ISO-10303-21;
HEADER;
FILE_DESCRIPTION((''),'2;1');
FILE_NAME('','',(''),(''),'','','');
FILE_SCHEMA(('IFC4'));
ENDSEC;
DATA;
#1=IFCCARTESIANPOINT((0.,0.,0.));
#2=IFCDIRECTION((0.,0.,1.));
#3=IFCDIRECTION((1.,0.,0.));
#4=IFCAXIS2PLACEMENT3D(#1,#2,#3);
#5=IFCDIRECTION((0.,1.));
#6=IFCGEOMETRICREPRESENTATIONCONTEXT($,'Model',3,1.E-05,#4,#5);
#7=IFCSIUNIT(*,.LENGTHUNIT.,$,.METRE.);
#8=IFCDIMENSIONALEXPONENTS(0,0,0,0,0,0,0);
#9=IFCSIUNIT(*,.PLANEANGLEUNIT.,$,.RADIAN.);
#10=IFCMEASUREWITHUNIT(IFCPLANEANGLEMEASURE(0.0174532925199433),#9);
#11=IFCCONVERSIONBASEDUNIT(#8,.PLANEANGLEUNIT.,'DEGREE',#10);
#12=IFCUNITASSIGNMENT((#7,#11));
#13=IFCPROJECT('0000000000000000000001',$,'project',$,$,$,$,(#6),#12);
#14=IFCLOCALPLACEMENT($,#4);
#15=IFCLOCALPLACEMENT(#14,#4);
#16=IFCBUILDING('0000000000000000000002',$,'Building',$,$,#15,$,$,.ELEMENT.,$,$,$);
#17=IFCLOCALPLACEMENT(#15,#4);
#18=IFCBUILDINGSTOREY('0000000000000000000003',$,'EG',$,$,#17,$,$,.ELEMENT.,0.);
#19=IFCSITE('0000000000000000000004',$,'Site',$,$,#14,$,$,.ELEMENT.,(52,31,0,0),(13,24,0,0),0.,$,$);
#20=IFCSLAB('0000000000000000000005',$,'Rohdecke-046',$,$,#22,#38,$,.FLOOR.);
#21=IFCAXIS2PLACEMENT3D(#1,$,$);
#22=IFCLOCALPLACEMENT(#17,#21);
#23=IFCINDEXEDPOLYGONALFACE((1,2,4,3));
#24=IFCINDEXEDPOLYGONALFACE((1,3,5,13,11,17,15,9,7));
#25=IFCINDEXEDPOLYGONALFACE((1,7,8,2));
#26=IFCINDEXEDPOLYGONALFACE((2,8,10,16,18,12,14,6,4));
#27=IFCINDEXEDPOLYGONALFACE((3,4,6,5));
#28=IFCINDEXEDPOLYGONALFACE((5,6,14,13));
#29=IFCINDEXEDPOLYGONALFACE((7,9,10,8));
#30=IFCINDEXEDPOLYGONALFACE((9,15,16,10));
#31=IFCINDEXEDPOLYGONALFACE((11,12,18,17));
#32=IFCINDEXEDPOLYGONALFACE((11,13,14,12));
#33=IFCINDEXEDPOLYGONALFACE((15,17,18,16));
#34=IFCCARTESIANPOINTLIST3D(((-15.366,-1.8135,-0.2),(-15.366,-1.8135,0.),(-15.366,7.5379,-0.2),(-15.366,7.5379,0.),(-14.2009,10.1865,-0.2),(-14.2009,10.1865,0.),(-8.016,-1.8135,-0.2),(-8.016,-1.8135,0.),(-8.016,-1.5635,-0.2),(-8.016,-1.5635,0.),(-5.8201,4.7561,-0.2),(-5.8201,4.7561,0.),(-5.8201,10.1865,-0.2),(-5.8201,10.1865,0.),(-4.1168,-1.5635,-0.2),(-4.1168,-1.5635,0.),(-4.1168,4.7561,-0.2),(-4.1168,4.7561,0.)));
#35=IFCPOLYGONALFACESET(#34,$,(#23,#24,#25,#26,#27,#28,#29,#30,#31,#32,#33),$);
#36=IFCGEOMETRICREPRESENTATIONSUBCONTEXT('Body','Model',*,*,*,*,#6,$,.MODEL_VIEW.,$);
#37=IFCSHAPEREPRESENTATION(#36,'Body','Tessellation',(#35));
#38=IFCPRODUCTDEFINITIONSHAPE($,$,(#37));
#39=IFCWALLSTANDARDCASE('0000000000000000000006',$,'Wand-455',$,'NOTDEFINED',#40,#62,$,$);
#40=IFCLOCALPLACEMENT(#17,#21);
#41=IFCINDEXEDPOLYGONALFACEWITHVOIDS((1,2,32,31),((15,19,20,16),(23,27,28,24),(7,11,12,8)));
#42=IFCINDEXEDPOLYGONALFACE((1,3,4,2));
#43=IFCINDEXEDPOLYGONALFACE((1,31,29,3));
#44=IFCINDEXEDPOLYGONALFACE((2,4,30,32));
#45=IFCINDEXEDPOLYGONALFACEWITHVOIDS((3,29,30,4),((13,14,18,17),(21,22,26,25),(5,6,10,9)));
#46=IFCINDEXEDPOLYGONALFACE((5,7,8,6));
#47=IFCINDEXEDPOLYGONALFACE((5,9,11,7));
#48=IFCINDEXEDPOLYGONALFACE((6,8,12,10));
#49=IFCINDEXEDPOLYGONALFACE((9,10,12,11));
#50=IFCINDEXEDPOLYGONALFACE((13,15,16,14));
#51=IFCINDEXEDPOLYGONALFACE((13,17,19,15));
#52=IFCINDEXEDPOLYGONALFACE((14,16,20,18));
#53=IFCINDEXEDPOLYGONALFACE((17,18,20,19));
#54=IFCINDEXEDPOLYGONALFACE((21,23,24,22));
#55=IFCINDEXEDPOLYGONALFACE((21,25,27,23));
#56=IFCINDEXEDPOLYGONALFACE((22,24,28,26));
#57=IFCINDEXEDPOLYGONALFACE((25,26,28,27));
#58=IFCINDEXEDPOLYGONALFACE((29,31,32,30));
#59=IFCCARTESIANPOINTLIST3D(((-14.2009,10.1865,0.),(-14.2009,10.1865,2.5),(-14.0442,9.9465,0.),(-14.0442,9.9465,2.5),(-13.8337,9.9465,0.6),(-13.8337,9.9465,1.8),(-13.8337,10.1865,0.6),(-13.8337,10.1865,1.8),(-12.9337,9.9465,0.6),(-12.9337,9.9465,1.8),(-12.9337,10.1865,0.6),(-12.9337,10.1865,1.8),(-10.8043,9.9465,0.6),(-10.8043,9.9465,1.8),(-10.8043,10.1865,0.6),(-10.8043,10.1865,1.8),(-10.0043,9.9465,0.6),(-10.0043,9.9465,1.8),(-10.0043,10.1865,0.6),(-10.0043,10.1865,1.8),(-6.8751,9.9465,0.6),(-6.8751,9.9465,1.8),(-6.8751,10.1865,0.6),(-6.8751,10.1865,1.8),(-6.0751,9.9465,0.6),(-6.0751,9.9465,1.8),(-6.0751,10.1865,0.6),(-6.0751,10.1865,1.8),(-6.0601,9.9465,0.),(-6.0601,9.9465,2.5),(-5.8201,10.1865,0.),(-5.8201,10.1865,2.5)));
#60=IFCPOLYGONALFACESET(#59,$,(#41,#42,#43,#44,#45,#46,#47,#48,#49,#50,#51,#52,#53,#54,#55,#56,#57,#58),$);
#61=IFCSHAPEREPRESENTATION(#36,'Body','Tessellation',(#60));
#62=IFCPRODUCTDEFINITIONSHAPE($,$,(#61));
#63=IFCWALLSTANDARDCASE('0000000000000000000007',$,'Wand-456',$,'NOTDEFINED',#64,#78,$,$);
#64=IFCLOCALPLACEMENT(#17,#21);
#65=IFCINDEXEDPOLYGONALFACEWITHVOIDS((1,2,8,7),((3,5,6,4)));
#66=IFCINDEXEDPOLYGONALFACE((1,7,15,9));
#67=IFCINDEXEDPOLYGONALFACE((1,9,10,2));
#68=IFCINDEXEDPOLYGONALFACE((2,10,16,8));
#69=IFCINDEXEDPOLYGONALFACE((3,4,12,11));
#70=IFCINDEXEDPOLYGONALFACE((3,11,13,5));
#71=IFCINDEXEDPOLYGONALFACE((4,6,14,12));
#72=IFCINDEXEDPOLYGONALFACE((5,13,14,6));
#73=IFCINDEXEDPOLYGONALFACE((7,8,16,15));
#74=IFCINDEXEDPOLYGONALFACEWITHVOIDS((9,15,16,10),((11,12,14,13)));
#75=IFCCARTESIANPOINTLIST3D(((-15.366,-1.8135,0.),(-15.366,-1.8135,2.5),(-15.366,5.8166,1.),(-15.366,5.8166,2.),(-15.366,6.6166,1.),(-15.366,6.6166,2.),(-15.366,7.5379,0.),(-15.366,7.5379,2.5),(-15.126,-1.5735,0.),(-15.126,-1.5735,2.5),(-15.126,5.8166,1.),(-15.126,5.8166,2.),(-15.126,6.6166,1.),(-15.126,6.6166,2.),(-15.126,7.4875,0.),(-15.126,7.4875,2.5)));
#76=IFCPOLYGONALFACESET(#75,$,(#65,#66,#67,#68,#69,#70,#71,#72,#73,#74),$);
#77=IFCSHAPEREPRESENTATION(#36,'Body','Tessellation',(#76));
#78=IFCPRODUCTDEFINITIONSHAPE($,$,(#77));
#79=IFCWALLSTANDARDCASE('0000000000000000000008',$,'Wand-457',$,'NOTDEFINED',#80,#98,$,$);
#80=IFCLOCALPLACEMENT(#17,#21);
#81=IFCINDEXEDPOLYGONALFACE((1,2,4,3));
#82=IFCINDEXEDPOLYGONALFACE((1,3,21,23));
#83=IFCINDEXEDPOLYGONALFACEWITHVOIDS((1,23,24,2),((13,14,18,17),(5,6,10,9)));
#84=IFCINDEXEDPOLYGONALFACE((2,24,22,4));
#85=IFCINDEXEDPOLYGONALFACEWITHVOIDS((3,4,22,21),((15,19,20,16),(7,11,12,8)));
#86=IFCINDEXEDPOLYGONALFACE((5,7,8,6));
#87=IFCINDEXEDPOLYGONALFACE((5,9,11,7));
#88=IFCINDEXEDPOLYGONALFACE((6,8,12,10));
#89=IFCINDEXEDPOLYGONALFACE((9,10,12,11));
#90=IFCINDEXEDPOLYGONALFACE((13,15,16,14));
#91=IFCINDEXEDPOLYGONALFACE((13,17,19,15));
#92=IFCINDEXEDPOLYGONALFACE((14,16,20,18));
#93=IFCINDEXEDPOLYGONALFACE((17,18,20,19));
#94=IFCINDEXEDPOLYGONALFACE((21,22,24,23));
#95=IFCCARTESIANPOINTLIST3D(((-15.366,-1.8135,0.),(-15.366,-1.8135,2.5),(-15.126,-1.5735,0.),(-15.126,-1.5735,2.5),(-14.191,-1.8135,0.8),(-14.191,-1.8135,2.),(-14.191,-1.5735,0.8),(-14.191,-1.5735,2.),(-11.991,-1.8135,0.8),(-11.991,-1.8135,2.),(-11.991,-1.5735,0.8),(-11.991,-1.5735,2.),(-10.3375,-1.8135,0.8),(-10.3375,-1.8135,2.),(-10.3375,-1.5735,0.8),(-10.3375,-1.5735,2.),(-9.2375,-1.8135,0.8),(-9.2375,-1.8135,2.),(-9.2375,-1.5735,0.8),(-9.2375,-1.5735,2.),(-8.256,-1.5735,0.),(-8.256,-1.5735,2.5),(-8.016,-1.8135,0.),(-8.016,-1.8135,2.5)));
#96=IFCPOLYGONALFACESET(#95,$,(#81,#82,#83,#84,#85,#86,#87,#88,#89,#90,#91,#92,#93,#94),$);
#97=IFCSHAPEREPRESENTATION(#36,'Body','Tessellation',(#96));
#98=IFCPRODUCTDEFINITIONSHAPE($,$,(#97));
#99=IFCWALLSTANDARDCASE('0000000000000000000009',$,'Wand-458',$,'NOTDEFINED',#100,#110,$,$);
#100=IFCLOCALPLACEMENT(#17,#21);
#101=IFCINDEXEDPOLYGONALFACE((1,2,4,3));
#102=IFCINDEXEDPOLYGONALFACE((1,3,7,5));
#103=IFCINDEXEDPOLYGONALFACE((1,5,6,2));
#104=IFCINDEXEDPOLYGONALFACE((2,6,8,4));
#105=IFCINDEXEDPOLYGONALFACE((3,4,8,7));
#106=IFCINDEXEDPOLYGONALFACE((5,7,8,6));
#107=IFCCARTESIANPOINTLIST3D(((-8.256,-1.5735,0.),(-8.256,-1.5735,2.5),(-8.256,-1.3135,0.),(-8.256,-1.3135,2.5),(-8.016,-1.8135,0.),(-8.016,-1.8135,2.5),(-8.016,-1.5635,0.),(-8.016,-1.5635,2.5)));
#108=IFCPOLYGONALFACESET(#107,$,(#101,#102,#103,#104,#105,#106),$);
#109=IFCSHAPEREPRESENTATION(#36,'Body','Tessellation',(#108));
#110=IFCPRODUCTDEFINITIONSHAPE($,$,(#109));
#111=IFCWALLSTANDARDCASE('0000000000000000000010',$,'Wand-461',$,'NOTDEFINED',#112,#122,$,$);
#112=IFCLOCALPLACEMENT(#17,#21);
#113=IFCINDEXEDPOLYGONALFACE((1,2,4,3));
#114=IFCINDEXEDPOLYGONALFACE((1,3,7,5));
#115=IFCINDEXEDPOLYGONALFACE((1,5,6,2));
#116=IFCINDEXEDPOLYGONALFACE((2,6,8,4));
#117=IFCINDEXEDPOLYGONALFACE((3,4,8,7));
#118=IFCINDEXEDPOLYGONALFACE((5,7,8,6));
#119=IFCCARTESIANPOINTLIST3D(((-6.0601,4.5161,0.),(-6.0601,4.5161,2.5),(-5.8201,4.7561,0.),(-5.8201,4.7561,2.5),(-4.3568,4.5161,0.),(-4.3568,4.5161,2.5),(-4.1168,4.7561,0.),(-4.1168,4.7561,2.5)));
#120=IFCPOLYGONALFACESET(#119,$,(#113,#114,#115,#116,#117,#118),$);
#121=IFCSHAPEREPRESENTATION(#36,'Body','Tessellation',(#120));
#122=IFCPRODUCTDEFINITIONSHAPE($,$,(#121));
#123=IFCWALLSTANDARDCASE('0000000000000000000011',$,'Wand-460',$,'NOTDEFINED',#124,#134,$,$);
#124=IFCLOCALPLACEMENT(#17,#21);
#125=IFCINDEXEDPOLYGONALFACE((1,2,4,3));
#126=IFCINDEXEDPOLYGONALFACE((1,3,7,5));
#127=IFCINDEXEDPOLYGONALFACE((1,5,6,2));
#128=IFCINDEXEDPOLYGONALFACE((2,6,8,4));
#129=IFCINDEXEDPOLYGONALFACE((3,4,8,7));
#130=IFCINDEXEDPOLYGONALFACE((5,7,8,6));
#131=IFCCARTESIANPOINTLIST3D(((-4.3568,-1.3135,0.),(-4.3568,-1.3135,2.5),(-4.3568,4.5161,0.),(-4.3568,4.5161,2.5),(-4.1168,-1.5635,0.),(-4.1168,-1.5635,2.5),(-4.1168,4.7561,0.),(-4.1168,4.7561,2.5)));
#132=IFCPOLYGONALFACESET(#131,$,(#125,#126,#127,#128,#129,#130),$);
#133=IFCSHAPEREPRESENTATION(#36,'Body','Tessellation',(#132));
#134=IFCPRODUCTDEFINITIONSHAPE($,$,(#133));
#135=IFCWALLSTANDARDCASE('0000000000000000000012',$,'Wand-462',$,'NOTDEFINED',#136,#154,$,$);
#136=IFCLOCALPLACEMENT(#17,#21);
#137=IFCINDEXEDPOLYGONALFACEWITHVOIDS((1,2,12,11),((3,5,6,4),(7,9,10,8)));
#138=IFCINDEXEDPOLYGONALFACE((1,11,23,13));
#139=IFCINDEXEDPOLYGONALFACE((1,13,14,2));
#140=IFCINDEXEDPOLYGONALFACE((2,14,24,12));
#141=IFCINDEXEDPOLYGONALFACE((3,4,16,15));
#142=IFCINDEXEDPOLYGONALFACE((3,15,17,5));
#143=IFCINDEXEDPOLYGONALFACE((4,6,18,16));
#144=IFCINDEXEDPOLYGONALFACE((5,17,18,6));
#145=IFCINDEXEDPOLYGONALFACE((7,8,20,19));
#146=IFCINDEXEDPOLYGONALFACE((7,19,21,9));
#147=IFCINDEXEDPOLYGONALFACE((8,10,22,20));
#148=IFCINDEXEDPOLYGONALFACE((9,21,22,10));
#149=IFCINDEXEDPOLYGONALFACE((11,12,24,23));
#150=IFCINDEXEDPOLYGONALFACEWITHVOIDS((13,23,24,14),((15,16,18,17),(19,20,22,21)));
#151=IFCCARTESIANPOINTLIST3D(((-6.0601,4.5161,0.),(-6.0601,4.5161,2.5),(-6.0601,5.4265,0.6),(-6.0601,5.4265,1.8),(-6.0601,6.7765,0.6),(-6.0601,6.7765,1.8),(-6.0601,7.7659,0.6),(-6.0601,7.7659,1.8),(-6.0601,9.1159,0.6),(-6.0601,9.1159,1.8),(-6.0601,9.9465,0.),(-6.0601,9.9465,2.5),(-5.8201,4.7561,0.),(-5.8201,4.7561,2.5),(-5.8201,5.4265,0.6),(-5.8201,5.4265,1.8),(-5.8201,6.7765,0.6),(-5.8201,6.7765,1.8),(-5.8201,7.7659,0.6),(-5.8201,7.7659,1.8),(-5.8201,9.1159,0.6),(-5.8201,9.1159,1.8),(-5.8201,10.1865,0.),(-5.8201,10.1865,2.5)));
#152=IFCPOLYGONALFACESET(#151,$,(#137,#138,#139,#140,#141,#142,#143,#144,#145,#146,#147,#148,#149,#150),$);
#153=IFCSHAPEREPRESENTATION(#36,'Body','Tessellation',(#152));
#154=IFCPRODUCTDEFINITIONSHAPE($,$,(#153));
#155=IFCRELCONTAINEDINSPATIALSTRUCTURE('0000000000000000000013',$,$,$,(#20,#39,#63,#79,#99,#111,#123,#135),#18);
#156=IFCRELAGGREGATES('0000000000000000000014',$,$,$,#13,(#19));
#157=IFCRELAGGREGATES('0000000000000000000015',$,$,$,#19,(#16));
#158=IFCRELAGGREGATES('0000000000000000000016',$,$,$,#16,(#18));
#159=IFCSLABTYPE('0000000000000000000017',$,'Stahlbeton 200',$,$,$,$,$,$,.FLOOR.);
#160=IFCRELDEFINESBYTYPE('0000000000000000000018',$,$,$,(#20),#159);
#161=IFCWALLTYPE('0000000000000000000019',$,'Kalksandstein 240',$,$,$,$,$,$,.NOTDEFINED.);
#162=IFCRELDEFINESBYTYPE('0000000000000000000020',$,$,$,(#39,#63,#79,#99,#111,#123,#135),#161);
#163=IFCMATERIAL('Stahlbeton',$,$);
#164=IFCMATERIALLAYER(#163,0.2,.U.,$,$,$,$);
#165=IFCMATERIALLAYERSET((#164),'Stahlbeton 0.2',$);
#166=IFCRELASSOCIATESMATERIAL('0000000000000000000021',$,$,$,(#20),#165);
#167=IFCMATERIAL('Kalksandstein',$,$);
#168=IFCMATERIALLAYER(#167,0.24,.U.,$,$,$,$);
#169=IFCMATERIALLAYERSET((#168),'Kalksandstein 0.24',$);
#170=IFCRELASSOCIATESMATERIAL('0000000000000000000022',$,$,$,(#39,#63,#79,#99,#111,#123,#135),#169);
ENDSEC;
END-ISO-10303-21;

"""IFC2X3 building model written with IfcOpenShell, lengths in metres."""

from ifc_helpers import new_model, entity, si_unit, converted_unit, direction, frame, origin_with_axes, origin_2d_with_axis, place, context, subcontext, project, spatial, polyline, rectangle, outline, extrude, material, layer, layer_set, layer_usage, type_object, element, save


model = new_model("IFC2X3")

# Units and contexts
model_context = context("Model", 3, precision=1e-05, world=origin_with_axes(), true_north=direction((0.0, 1.0)))
body_context = subcontext(model_context, "Body", "Model", "MODEL_VIEW")
ifc_project = project(units=[si_unit("LENGTHUNIT", "METRE"), converted_unit("PLANEANGLEUNIT", "DEGREE", entity("IfcPlaneAngleMeasure", 0.0174532925199433), si_unit("PLANEANGLEUNIT", "RADIAN"), dimensions=[0, 0, 0, 0, 0, 0, 0])], contexts=[model_context])

# Site, building, storey
site_placement = place(None, origin_with_axes())
site = spatial("IfcSite", under=ifc_project, at=site_placement, Name="Site", CompositionType="ELEMENT", RefLatitude=(52, 31, 0, 0), RefLongitude=(13, 24, 0, 0), RefElevation=0.0)
building_placement = place(site_placement, origin_with_axes())
building = spatial("IfcBuilding", under=site, at=building_placement, Name="Building", CompositionType="ELEMENT")
storey_placement = place(building_placement, origin_with_axes())
storey = spatial("IfcBuildingStorey", under=building, at=storey_placement, Name="EG", CompositionType="ELEMENT", Elevation=0.0)

# Slab
ifc_material_1 = material(Name="Stahlbeton")
ifc_layer_1 = layer(ifc_material_1, 0.2, ventilated="UNKNOWN")
ifc_layer_set_1 = layer_set([ifc_layer_1], Name="Stahlbeton 0.2")
ifc_layer_usage_1 = layer_usage(ifc_layer_set_1, "AXIS3", "NEGATIVE", 0.2)
slab_type = type_object("IfcSlabType", Name="Stahlbeton 200", PredefinedType="FLOOR")
slab_placement = place(storey_placement, frame((-14.2009, 10.1865, 0.0), z_axis=(0.0, 0.0, 1.0), x_axis=(1.0, 0.0, 0.0)))
element("IfcSlab", 1, at=slab_placement, inside=storey, type_object=slab_type, material=ifc_layer_usage_1, Name="Rohdecke-046", PredefinedType="FLOOR", context=body_context, shape_type="SweptSolid", body=[
    extrude(outline(polyline([(0.0, 0.0), (-1.1652, -2.6486), (-1.1652, -12.0), (6.1848, -12.0), (6.1848, -11.75), (10.084, -11.75), (10.084, -5.4304), (8.3807, -5.4304), (8.3807, 0.0), (0.0, 0.0)])), frame((0.0, 0.0, -0.2), z_axis=(0.0, 0.0, 1.0), x_axis=(1.0, 0.0, 0.0)), (0.0, 0.0, 1.0), 0.2),
])

# Wall, openings
ifc_material_2 = material(Name="Kalksandstein")
ifc_layer_2 = layer(ifc_material_2, 0.24, ventilated="UNKNOWN")
ifc_layer_set_2 = layer_set([ifc_layer_2], Name="Kalksandstein 0.24")
ifc_layer_usage_2 = layer_usage(ifc_layer_set_2, "AXIS2", "POSITIVE", 0.0)
wall_type_1 = type_object("IfcWallType", Name="Kalksandstein 240", PredefinedType="NOTDEFINED")
wall_1_placement = place(storey_placement, frame((-5.8201, 10.1865, 0.0), z_axis=(0.0, 0.0, 1.0), x_axis=(-1.0, 0.0, 0.0)))
wall_1 = element("IfcWallStandardCase", 2, at=wall_1_placement, inside=storey, type_object=wall_type_1, material=ifc_layer_usage_2, Name="Wand-455", ObjectType="NOTDEFINED", context=body_context, shape_type="SweptSolid", body=[
    extrude(outline(polyline([(0.0, 0.0), (8.3807, 0.0), (8.2241, 0.24), (0.24, 0.24), (0.0, 0.0)])), origin_with_axes(), (0.0, 0.0, 1.0), 2.5),
])
opening_1_placement = place(wall_1_placement, frame((7.5636, 0.0, 0.6), z_axis=(0.0, 0.0, 1.0), x_axis=(1.0, 0.0, 0.0)))
element("IfcOpeningElement", 3, at=opening_1_placement, cuts=wall_1, context=body_context, shape_type="SweptSolid", body=[
    extrude(rectangle(XDim=0.9, YDim=1.2, at=origin_2d_with_axis()), frame((0.0, 0.24, 0.6), z_axis=(0.0, 1.0, 0.0), x_axis=(1.0, 0.0, 0.0)), (0.0, 0.0, -1.0), 0.72),
])
opening_2_placement = place(wall_1_placement, frame((0.655, 0.0, 0.6), z_axis=(0.0, 0.0, 1.0), x_axis=(1.0, 0.0, 0.0)))
element("IfcOpeningElement", 4, at=opening_2_placement, cuts=wall_1, context=body_context, shape_type="SweptSolid", body=[
    extrude(rectangle(XDim=0.8, YDim=1.2, at=origin_2d_with_axis()), frame((0.0, 0.24, 0.6), z_axis=(0.0, 1.0, 0.0), x_axis=(1.0, 0.0, 0.0)), (0.0, 0.0, -1.0), 0.72),
])
opening_3_placement = place(wall_1_placement, frame((4.5842, 0.0, 0.6), z_axis=(0.0, 0.0, 1.0), x_axis=(1.0, 0.0, 0.0)))
element("IfcOpeningElement", 5, at=opening_3_placement, cuts=wall_1, context=body_context, shape_type="SweptSolid", body=[
    extrude(rectangle(XDim=0.8, YDim=1.2, at=origin_2d_with_axis()), frame((0.0, 0.24, 0.6), z_axis=(0.0, 1.0, 0.0), x_axis=(1.0, 0.0, 0.0)), (0.0, 0.0, -1.0), 0.72),
])

# Wall, opening
ifc_layer_usage_3 = layer_usage(ifc_layer_set_2, "AXIS2", "POSITIVE", 0.0)
wall_2_placement = place(storey_placement, frame((-15.366, 7.5379, 0.0), z_axis=(0.0, 0.0, 1.0), x_axis=(0.0, -1.0, 0.0)))
wall_2 = element("IfcWallStandardCase", 6, at=wall_2_placement, inside=storey, type_object=wall_type_1, material=ifc_layer_usage_3, Name="Wand-456", ObjectType="NOTDEFINED", context=body_context, shape_type="SweptSolid", body=[
    extrude(outline(polyline([(0.0, 0.0), (9.3514, 0.0), (9.1114, 0.24), (0.0505, 0.24), (0.0, 0.0)])), origin_with_axes(), (0.0, 0.0, 1.0), 2.5),
])
opening_4_placement = place(wall_2_placement, frame((1.3213, 0.0, 1.0), z_axis=(0.0, 0.0, 1.0), x_axis=(1.0, 0.0, 0.0)))
element("IfcOpeningElement", 7, at=opening_4_placement, cuts=wall_2, context=body_context, shape_type="SweptSolid", body=[
    extrude(rectangle(XDim=0.8, YDim=1.0, at=origin_2d_with_axis()), frame((0.0, 0.24, 0.5), z_axis=(0.0, 1.0, 0.0), x_axis=(1.0, 0.0, 0.0)), (0.0, 0.0, -1.0), 0.72),
])

# Wall, openings
ifc_layer_usage_4 = layer_usage(ifc_layer_set_2, "AXIS2", "POSITIVE", 0.0)
wall_3_placement = place(storey_placement, frame((-15.366, -1.8135, 0.0), z_axis=(0.0, 0.0, 1.0), x_axis=(1.0, 0.0, 0.0)))
wall_3 = element("IfcWallStandardCase", 8, at=wall_3_placement, inside=storey, type_object=wall_type_1, material=ifc_layer_usage_4, Name="Wand-457", ObjectType="NOTDEFINED", context=body_context, shape_type="SweptSolid", body=[
    extrude(outline(polyline([(0.0, 0.0), (7.35, 0.0), (7.11, 0.24), (0.24, 0.24), (0.0, 0.0)])), origin_with_axes(), (0.0, 0.0, 1.0), 2.5),
])
opening_5_placement = place(wall_3_placement, frame((5.5785, 0.0, 0.8), z_axis=(0.0, 0.0, 1.0), x_axis=(1.0, 0.0, 0.0)))
element("IfcOpeningElement", 9, at=opening_5_placement, cuts=wall_3, context=body_context, shape_type="SweptSolid", body=[
    extrude(rectangle(XDim=1.1, YDim=1.2, at=origin_2d_with_axis()), frame((0.0, 0.24, 0.6), z_axis=(0.0, 1.0, 0.0), x_axis=(1.0, 0.0, 0.0)), (0.0, 0.0, -1.0), 0.72),
])
opening_6_placement = place(wall_3_placement, frame((2.275, 0.0, 0.8), z_axis=(0.0, 0.0, 1.0), x_axis=(1.0, 0.0, 0.0)))
element("IfcOpeningElement", 10, at=opening_6_placement, cuts=wall_3, context=body_context, shape_type="SweptSolid", body=[
    extrude(rectangle(XDim=2.2, YDim=1.2, at=origin_2d_with_axis()), frame((0.0, 0.24, 0.6), z_axis=(0.0, 1.0, 0.0), x_axis=(1.0, 0.0, 0.0)), (0.0, 0.0, -1.0), 0.72),
])

# Walls
ifc_layer_usage_5 = layer_usage(ifc_layer_set_2, "AXIS2", "POSITIVE", 0.0)
wall_4_placement = place(storey_placement, frame((-8.016, -1.8135, 0.0), z_axis=(0.0, 0.0, 1.0), x_axis=(0.0, 1.0, 0.0)))
element("IfcWallStandardCase", 11, at=wall_4_placement, inside=storey, type_object=wall_type_1, material=ifc_layer_usage_5, Name="Wand-458", ObjectType="NOTDEFINED", context=body_context, shape_type="SweptSolid", body=[
    extrude(outline(polyline([(0.0, 0.0), (0.25, 0.0), (0.5, 0.24), (0.24, 0.24), (0.0, 0.0)])), origin_with_axes(), (0.0, 0.0, 1.0), 2.5),
])
ifc_layer_usage_6 = layer_usage(ifc_layer_set_2, "AXIS2", "POSITIVE", 0.0)
wall_5_placement = place(storey_placement, frame((-4.1168, 4.7561, 0.0), z_axis=(0.0, 0.0, 1.0), x_axis=(-1.0, 0.0, 0.0)))
element("IfcWallStandardCase", 12, at=wall_5_placement, inside=storey, type_object=wall_type_1, material=ifc_layer_usage_6, Name="Wand-461", ObjectType="NOTDEFINED", context=body_context, shape_type="SweptSolid", body=[
    extrude(outline(polyline([(0.0, 0.0), (1.7033, 0.0), (1.9433, 0.24), (0.24, 0.24), (0.0, 0.0)])), origin_with_axes(), (0.0, 0.0, 1.0), 2.5),
])
ifc_layer_usage_7 = layer_usage(ifc_layer_set_2, "AXIS2", "POSITIVE", 0.0)
wall_6_placement = place(storey_placement, frame((-4.1168, -1.5635, 0.0), z_axis=(0.0, 0.0, 1.0), x_axis=(0.0, 1.0, 0.0)))
element("IfcWallStandardCase", 13, at=wall_6_placement, inside=storey, type_object=wall_type_1, material=ifc_layer_usage_7, Name="Wand-460", ObjectType="NOTDEFINED", context=body_context, shape_type="SweptSolid", body=[
    extrude(outline(polyline([(0.0, 0.0), (6.3196, 0.0), (6.0796, 0.24), (0.25, 0.24), (0.0, 0.0)])), origin_with_axes(), (0.0, 0.0, 1.0), 2.5),
])

# Wall, openings
ifc_layer_usage_8 = layer_usage(ifc_layer_set_2, "AXIS2", "POSITIVE", 0.0)
wall_7_placement = place(storey_placement, frame((-5.8201, 4.7561, 0.0), z_axis=(0.0, 0.0, 1.0), x_axis=(0.0, 1.0, 0.0)))
wall_7 = element("IfcWallStandardCase", 14, at=wall_7_placement, inside=storey, type_object=wall_type_1, material=ifc_layer_usage_8, Name="Wand-462", ObjectType="NOTDEFINED", context=body_context, shape_type="SweptSolid", body=[
    extrude(outline(polyline([(0.0, 0.0), (5.4304, 0.0), (5.1904, 0.24), (-0.24, 0.24), (0.0, 0.0)])), origin_with_axes(), (0.0, 0.0, 1.0), 2.5),
])
opening_7_placement = place(wall_7_placement, frame((1.3454, 0.0, 0.6), z_axis=(0.0, 0.0, 1.0), x_axis=(1.0, 0.0, 0.0)))
element("IfcOpeningElement", 15, at=opening_7_placement, cuts=wall_7, context=body_context, shape_type="SweptSolid", body=[
    extrude(rectangle(XDim=1.35, YDim=1.2, at=origin_2d_with_axis()), frame((0.0, 0.24, 0.6), z_axis=(0.0, 1.0, 0.0), x_axis=(1.0, 0.0, 0.0)), (0.0, 0.0, -1.0), 0.72),
])
opening_8_placement = place(wall_7_placement, frame((3.6849, 0.0, 0.6), z_axis=(0.0, 0.0, 1.0), x_axis=(1.0, 0.0, 0.0)))
element("IfcOpeningElement", 16, at=opening_8_placement, cuts=wall_7, context=body_context, shape_type="SweptSolid", body=[
    extrude(rectangle(XDim=1.35, YDim=1.2, at=origin_2d_with_axis()), frame((0.0, 0.24, 0.6), z_axis=(0.0, 1.0, 0.0), x_axis=(1.0, 0.0, 0.0)), (0.0, 0.0, -1.0), 0.72),
])

save(model, "model.ifc")
